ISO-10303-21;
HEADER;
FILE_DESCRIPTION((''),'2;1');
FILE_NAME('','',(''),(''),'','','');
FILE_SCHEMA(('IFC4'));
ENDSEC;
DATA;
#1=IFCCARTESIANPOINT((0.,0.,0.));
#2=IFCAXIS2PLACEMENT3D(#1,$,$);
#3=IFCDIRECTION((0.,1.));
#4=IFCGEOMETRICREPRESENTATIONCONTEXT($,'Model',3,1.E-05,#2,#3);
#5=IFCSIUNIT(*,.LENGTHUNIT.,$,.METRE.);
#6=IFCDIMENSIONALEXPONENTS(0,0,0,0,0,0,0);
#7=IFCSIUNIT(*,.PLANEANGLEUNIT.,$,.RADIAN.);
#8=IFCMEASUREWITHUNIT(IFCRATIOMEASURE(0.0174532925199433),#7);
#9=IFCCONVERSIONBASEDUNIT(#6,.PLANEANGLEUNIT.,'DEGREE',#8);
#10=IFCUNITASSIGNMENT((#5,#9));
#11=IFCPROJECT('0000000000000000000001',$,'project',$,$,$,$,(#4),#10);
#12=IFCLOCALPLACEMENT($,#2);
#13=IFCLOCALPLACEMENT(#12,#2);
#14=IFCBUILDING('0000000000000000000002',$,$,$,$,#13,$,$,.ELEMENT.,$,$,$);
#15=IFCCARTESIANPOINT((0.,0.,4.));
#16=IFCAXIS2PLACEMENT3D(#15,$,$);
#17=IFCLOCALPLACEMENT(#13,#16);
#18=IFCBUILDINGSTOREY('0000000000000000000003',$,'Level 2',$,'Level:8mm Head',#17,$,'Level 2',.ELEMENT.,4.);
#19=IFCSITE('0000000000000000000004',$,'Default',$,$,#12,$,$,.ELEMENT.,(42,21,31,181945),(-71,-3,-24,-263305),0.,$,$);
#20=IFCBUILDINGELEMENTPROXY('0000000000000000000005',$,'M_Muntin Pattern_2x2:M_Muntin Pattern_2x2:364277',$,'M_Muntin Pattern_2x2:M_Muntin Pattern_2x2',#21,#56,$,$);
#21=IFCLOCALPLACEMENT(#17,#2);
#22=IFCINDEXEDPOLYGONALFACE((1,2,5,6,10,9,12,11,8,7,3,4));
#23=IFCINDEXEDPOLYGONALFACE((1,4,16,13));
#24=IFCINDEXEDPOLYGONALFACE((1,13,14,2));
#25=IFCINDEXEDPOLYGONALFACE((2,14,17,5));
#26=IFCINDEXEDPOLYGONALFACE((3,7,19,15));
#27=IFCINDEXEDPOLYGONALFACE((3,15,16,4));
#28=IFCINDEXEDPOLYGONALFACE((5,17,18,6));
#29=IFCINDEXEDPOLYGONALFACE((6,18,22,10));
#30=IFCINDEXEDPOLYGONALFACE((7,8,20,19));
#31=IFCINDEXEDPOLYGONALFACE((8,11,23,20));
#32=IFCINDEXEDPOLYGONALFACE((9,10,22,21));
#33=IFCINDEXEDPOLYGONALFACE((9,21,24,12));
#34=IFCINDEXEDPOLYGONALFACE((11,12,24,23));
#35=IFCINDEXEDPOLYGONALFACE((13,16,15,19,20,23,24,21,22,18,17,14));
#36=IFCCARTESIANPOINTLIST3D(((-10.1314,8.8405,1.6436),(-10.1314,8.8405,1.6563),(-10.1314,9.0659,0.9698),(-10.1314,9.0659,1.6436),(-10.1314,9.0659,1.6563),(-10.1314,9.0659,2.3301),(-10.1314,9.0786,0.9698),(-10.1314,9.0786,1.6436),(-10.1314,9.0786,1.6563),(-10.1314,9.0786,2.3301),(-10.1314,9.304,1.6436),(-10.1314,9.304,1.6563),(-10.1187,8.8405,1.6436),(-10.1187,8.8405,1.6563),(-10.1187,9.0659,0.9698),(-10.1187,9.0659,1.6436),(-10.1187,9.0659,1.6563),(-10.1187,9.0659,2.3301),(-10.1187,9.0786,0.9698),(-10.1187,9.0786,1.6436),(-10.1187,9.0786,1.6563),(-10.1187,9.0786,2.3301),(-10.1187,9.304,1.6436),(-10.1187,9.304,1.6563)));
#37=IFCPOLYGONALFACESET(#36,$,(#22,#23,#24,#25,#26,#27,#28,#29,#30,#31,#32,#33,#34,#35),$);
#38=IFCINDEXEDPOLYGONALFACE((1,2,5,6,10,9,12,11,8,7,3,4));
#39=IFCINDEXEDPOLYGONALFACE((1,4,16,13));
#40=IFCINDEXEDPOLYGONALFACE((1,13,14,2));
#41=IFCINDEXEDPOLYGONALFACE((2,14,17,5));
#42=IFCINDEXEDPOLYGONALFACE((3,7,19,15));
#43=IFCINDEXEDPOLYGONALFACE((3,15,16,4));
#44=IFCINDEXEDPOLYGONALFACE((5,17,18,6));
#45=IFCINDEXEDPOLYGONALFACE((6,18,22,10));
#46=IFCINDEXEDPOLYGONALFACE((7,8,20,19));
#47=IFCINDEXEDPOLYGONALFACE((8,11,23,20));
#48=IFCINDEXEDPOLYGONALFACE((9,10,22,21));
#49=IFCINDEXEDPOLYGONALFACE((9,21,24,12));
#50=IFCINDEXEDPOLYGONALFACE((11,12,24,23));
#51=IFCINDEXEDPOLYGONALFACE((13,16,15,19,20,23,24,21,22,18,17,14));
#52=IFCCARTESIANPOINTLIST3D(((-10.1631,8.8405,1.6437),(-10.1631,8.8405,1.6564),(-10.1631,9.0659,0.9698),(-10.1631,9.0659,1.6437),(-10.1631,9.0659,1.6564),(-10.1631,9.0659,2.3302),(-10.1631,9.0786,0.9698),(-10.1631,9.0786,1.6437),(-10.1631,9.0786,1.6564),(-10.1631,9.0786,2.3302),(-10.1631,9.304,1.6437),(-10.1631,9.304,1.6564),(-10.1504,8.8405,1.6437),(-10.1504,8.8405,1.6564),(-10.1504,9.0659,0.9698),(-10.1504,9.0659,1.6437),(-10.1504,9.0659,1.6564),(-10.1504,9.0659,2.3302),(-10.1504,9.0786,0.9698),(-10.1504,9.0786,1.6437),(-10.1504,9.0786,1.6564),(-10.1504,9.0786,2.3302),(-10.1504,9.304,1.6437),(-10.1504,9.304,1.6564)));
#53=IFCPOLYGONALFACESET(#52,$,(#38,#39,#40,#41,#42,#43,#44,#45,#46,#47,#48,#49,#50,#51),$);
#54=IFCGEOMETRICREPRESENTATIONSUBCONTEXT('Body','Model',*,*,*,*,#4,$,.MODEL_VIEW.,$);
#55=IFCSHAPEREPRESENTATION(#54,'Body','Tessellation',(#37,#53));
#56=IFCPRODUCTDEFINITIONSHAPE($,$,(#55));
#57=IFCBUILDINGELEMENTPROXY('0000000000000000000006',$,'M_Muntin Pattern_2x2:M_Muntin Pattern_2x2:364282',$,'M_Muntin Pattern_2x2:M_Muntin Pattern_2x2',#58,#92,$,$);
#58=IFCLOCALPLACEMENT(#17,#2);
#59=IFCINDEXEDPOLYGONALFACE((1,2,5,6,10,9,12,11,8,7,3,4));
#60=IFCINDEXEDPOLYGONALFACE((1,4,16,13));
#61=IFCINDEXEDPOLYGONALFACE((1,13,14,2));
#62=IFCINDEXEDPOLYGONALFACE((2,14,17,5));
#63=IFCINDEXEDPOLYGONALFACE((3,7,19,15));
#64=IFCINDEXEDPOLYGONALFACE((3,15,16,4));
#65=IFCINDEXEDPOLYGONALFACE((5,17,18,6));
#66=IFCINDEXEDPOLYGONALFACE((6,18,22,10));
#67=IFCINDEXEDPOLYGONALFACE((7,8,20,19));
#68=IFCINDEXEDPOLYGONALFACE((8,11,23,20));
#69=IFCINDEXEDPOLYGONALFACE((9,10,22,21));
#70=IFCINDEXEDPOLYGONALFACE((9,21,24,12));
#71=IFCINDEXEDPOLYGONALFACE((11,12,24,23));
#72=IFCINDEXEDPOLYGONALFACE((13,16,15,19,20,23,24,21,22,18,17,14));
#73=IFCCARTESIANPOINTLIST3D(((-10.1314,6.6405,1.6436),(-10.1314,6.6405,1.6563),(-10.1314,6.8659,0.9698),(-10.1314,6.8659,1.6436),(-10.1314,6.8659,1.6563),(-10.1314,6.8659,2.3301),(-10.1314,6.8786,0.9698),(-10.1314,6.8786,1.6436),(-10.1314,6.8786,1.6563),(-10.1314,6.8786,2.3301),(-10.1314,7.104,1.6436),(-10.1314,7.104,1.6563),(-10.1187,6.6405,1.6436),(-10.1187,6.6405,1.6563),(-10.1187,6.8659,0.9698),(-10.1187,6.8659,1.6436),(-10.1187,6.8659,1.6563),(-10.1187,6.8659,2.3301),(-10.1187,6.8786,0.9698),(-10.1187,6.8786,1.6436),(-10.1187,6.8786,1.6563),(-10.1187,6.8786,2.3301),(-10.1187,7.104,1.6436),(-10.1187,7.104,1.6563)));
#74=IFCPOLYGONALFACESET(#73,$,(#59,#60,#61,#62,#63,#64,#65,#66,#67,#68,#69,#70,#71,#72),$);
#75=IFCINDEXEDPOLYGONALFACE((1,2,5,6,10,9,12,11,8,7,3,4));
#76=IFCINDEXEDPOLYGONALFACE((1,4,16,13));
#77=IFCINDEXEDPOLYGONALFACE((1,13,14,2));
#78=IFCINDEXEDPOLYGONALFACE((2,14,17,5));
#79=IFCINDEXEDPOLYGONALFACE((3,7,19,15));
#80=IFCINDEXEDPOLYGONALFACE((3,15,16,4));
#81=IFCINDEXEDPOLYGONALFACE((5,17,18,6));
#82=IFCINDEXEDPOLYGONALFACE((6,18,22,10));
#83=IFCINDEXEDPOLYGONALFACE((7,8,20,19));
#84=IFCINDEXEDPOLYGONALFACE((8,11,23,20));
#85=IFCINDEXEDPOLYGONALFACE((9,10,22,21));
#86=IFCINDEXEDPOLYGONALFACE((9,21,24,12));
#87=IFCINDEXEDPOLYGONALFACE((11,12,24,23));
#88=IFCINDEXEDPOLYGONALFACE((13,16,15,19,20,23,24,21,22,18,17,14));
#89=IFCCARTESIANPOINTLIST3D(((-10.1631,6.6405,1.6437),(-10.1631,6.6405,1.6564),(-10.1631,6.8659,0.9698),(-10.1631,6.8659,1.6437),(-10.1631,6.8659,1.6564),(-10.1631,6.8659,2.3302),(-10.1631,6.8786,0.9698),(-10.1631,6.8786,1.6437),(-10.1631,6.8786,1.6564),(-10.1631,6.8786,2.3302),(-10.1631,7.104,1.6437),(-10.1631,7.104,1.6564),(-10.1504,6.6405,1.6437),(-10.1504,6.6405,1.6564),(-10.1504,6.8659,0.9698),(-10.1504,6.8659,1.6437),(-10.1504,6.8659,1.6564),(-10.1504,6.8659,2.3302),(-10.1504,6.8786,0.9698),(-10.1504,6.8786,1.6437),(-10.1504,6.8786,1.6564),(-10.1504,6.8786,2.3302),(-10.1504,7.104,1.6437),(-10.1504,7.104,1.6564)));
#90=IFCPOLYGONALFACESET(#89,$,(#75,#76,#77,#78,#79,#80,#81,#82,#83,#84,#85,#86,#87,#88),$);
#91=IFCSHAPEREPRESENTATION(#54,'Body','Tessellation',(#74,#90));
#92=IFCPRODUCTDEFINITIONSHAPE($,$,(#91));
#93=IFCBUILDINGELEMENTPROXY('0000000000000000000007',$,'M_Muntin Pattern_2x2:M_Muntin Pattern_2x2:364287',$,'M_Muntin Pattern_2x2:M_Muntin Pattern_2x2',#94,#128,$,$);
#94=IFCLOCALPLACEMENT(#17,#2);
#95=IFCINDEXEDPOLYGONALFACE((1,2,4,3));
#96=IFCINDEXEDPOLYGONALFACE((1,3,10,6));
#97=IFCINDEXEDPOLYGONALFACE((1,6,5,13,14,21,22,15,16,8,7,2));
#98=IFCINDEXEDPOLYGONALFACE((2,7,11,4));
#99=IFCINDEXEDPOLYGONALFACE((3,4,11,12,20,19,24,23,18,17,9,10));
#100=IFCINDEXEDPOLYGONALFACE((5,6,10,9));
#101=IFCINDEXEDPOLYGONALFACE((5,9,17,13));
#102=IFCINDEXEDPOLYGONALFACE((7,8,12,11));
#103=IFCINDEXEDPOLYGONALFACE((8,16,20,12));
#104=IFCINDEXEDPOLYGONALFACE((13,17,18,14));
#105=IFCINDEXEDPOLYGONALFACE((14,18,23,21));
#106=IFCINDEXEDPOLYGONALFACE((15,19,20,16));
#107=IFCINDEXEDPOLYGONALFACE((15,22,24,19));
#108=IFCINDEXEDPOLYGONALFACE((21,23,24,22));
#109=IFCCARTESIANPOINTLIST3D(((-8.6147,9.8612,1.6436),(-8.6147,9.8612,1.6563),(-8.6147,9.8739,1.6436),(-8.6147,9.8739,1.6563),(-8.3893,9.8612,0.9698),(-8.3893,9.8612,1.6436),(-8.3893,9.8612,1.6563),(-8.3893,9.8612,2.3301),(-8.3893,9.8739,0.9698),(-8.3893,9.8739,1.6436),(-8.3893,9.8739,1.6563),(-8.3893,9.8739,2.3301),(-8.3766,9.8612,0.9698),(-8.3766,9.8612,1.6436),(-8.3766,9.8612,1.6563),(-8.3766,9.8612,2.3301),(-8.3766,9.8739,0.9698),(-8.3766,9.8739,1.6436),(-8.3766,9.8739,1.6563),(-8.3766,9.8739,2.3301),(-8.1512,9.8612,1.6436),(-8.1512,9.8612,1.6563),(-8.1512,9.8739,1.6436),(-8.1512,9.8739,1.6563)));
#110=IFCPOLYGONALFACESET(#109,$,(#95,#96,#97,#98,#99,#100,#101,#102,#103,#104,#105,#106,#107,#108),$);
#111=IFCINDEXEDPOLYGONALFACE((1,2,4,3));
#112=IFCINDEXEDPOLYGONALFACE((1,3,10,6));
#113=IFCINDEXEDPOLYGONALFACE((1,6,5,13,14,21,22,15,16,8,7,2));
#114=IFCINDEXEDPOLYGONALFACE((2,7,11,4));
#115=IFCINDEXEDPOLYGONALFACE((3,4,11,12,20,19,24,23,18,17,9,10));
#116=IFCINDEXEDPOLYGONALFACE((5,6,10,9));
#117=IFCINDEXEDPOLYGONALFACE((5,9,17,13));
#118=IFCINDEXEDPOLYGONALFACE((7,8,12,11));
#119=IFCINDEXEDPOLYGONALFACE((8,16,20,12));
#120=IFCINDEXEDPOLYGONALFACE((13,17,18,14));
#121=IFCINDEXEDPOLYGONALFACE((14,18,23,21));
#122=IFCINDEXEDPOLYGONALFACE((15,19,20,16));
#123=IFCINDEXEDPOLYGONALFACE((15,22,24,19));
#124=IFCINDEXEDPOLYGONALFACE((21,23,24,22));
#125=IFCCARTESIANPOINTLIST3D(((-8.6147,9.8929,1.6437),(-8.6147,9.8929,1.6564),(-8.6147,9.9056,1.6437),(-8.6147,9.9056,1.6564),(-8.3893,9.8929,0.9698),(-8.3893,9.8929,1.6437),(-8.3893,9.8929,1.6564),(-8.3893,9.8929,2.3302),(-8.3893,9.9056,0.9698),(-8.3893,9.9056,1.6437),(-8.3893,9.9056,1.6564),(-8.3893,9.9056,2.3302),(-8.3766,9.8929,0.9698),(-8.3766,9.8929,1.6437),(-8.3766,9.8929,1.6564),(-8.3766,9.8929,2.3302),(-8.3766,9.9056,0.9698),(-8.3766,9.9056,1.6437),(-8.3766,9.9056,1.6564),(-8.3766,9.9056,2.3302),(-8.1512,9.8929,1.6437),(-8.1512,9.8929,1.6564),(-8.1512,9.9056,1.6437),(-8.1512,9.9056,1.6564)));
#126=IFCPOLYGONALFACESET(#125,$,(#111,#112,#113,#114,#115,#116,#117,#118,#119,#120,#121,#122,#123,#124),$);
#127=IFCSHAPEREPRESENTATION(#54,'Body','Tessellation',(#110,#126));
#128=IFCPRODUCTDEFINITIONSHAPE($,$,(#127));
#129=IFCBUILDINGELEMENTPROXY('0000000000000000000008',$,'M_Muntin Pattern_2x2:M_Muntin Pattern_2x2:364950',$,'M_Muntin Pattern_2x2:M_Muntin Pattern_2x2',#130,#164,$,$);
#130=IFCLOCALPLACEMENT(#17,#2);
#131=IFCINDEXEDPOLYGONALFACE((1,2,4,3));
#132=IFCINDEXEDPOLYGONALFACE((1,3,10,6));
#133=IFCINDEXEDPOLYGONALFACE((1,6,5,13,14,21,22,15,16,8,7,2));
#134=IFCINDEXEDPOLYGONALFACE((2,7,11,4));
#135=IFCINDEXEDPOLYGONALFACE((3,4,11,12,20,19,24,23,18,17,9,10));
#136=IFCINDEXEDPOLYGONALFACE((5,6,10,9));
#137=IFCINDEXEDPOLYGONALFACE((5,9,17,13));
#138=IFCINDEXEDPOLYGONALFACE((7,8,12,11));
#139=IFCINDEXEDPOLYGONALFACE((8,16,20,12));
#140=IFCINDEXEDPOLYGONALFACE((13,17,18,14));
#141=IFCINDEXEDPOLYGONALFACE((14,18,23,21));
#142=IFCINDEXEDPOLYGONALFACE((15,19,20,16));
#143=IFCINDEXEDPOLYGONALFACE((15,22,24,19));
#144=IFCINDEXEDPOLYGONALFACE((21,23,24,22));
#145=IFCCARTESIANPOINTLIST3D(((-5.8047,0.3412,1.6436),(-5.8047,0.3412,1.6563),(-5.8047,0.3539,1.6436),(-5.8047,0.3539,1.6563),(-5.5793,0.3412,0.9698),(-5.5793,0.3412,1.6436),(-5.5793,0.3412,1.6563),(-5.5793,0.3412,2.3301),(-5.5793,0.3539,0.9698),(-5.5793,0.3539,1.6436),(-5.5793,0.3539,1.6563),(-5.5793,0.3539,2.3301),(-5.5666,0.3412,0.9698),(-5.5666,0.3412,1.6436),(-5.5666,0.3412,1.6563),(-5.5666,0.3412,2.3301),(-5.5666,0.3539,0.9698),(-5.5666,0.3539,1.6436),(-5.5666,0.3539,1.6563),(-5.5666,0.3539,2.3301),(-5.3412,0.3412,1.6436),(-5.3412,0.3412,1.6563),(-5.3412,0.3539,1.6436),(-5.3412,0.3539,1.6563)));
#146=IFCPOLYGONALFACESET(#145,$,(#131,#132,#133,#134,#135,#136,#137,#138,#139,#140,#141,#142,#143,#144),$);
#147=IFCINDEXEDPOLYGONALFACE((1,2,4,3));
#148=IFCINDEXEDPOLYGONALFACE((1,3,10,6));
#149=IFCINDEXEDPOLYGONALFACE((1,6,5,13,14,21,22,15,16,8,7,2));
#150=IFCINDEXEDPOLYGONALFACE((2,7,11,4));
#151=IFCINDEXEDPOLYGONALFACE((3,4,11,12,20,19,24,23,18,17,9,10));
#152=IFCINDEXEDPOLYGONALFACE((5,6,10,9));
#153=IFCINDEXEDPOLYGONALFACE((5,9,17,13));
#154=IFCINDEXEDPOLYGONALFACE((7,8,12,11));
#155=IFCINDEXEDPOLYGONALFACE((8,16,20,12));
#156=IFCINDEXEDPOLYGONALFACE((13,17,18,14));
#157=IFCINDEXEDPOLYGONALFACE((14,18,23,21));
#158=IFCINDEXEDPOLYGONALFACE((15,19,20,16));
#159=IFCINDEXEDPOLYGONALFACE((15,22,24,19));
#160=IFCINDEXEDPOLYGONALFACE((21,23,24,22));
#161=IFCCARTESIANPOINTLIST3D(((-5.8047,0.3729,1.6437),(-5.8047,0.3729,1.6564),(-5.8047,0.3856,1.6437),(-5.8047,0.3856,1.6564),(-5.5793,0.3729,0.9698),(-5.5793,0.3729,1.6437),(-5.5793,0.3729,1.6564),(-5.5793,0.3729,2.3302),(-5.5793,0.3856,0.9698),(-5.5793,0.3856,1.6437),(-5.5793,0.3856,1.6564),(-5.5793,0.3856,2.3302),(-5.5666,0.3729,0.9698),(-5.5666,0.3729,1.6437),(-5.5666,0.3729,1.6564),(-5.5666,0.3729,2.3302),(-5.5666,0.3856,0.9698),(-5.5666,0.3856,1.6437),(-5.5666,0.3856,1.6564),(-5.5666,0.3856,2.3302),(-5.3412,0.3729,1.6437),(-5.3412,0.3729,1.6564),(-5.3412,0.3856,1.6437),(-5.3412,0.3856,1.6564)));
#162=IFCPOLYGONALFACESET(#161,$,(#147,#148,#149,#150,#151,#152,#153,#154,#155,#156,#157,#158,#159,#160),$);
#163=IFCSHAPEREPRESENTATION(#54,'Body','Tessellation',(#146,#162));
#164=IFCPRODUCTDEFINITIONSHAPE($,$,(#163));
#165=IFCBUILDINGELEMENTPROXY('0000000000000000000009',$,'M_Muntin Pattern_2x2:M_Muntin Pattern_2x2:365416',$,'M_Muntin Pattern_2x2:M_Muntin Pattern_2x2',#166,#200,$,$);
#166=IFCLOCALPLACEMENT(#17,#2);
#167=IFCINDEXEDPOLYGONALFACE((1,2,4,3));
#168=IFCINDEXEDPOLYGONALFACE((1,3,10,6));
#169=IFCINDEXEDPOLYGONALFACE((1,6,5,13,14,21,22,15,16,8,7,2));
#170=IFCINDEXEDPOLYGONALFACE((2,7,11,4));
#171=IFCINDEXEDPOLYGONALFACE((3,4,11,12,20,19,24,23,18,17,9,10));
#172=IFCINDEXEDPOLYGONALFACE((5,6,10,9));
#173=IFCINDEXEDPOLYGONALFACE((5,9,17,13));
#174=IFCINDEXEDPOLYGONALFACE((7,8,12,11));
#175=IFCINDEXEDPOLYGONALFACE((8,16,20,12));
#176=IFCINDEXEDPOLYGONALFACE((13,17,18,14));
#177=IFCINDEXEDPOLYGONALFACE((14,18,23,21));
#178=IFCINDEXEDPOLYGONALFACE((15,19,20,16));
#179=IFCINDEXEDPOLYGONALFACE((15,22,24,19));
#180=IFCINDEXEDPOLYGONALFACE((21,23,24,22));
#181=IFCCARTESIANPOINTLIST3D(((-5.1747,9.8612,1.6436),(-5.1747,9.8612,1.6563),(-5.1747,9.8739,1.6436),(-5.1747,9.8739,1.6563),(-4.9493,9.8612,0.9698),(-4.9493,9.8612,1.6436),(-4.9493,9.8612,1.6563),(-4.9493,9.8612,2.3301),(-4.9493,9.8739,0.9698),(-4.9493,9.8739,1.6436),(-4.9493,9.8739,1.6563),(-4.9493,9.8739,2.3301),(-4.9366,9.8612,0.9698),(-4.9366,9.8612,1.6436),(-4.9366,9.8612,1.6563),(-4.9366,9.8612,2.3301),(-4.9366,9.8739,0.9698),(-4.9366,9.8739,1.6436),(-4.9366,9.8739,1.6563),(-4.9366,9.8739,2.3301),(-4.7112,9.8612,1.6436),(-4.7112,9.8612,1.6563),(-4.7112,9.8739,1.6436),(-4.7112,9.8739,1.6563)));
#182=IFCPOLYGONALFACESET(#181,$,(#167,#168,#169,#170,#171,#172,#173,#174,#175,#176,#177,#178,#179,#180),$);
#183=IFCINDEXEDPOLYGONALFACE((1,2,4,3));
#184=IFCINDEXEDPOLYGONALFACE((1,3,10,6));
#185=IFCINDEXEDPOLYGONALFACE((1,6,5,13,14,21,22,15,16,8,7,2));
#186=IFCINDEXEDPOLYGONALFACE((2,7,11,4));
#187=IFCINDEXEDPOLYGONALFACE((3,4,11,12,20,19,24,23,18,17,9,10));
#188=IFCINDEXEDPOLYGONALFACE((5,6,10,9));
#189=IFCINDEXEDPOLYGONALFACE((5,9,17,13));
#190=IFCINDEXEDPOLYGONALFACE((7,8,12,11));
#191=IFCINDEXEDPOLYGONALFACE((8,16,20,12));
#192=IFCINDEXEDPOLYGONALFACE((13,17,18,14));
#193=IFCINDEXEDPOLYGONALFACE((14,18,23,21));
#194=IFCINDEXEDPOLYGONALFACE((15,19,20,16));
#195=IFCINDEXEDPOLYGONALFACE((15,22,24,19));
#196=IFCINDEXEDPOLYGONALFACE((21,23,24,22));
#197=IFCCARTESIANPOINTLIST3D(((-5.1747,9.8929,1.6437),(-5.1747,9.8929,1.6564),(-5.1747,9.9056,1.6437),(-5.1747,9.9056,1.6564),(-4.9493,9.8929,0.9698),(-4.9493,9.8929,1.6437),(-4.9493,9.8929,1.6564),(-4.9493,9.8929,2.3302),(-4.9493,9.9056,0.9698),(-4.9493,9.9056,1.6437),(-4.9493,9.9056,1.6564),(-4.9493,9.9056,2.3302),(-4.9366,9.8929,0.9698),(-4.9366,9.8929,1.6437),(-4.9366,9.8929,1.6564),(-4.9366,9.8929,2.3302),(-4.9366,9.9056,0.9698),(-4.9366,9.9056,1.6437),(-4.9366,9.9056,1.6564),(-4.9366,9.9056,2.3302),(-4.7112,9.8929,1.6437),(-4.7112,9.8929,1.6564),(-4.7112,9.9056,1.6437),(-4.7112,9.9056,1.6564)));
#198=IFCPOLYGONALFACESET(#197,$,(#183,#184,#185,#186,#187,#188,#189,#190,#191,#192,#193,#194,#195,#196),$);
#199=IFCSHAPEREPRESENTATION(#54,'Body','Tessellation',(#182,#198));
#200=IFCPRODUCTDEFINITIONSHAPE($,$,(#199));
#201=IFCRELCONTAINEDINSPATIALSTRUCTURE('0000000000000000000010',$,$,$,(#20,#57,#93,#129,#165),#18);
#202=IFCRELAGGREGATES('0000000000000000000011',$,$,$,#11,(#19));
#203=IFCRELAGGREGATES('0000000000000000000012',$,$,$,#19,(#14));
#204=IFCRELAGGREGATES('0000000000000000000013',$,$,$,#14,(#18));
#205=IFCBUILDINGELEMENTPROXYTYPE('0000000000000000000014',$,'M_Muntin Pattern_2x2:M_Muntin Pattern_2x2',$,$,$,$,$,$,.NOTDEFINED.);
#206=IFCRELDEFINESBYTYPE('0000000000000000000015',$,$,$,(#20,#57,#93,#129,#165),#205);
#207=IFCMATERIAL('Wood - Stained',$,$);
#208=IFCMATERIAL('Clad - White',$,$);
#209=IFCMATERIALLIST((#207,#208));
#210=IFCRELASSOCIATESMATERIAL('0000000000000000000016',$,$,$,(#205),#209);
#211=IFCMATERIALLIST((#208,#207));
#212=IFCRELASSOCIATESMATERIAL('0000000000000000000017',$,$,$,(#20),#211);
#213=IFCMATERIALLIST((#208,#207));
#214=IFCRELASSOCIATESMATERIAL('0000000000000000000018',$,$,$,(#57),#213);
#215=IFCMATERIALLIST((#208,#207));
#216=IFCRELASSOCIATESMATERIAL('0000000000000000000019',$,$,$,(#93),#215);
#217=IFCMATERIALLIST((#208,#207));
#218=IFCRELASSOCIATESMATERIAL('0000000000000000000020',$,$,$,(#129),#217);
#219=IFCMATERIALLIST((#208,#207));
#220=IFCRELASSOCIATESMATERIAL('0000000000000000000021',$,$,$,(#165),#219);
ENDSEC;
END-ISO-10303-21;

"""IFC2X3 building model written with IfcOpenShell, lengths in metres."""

from ifc_helpers import new_model, entity, si_unit, converted_unit, direction, frame, origin, place, context, subcontext, project, spatial, polyline, outline, extrude, source, transform, mapped, material, material_list, type_object, type_shapes, element, save


model = new_model("IFC2X3")

# Units and contexts
model_context = context("Model", 3, precision=1e-05, world=origin(), true_north=direction((0.0, 1.0)))
body_context = subcontext(model_context, "Body", "Model", "MODEL_VIEW")
ifc_project = project(units=[si_unit("LENGTHUNIT", "METRE"), converted_unit("PLANEANGLEUNIT", "DEGREE", entity("IfcRatioMeasure", 0.0174532925199433), si_unit("PLANEANGLEUNIT", "RADIAN"), dimensions=[0, 0, 0, 0, 0, 0, 0])], contexts=[model_context])

# Site, building, storey
site_placement = place(None, origin())
site = spatial("IfcSite", under=ifc_project, at=site_placement, Name="Default", CompositionType="ELEMENT", RefLatitude=(42, 21, 31, 181945), RefLongitude=(-71, -3, -24, -263305), RefElevation=0.0)
building_placement = place(site_placement, origin())
building = spatial("IfcBuilding", under=site, at=building_placement, CompositionType="ELEMENT")
storey_placement = place(building_placement, frame((0.0, 0.0, 4.0)))
storey = spatial("IfcBuildingStorey", under=building, at=storey_placement, Name="Level 2", ObjectType="Level:8mm Head", LongName="Level 2", CompositionType="ELEMENT", Elevation=4.0)

# Building element proxies
ifc_material_1 = material(Name="Clad - White")
ifc_material_2 = material(Name="Wood - Stained")
ifc_material_list_1 = material_list([ifc_material_1, ifc_material_2])
ifc_material_list_2 = material_list([ifc_material_2, ifc_material_1])
building_element_proxy_type_1 = type_object("IfcBuildingElementProxyType", Name="M_Muntin Pattern_2x2:M_Muntin Pattern_2x2", PredefinedType="NOTDEFINED", material=ifc_material_list_2)
shared_shape_1 = source(origin(), body_context, "Body", "SweptSolid", [
    extrude(outline(polyline([(0.0064, -0.0064), (0.6801, -0.0064), (0.6801, 0.0063), (0.0064, 0.0063), (0.0064, 0.2317), (-0.0063, 0.2317), (-0.0063, 0.0063), (-0.6802, 0.0063), (-0.6802, -0.0064), (-0.0063, -0.0064), (-0.0063, -0.2317), (0.0064, -0.2317), (0.0064, -0.0064)])), frame((0.0, 0.0095, 0.6801), z_axis=(0.0, 1.0, 0.0), x_axis=(0.0, 0.0, 1.0)), (0.0, 0.0, 1.0), 0.0127),
    extrude(outline(polyline([(0.0064, -0.0064), (0.6802, -0.0064), (0.6802, 0.0063), (0.0064, 0.0063), (0.0064, 0.2317), (-0.0063, 0.2317), (-0.0063, 0.0063), (-0.6802, 0.0063), (-0.6802, -0.0064), (-0.0063, -0.0064), (-0.0063, -0.2317), (0.0064, -0.2317), (0.0064, -0.0064)])), frame((0.0, -0.0222, 0.6802), z_axis=(0.0, 1.0, 0.0), x_axis=(0.0, 0.0, 1.0)), (0.0, 0.0, 1.0), 0.0127),
])
type_shapes(building_element_proxy_type_1, [shared_shape_1])
proxy_1_placement = place(storey_placement, frame((-10.1409, 9.0723, 0.9698), z_axis=(0.0, 0.0, 1.0), x_axis=(0.0, -1.0, 0.0)))
element("IfcBuildingElementProxy", 1, at=proxy_1_placement, inside=storey, type_object=building_element_proxy_type_1, material=ifc_material_list_1, Name="M_Muntin Pattern_2x2:M_Muntin Pattern_2x2:364277", ObjectType="M_Muntin Pattern_2x2:M_Muntin Pattern_2x2", context=body_context, shape_type="MappedRepresentation", body=[
    mapped(shared_shape_1, transform((0.0, 0.0, 0.0), scale=1.0)),
])
ifc_material_list_3 = material_list([ifc_material_1, ifc_material_2])
proxy_2_placement = place(storey_placement, frame((-10.1409, 6.8723, 0.9698), z_axis=(0.0, 0.0, 1.0), x_axis=(0.0, -1.0, 0.0)))
element("IfcBuildingElementProxy", 2, at=proxy_2_placement, inside=storey, type_object=building_element_proxy_type_1, material=ifc_material_list_3, Name="M_Muntin Pattern_2x2:M_Muntin Pattern_2x2:364282", ObjectType="M_Muntin Pattern_2x2:M_Muntin Pattern_2x2", context=body_context, shape_type="MappedRepresentation", body=[
    mapped(shared_shape_1, transform((0.0, 0.0, 0.0), scale=1.0)),
])
ifc_material_list_4 = material_list([ifc_material_1, ifc_material_2])
proxy_3_placement = place(storey_placement, frame((-8.383, 9.8834, 0.9698), z_axis=(0.0, 0.0, 1.0), x_axis=(-1.0, 0.0, 0.0)))
element("IfcBuildingElementProxy", 3, at=proxy_3_placement, inside=storey, type_object=building_element_proxy_type_1, material=ifc_material_list_4, Name="M_Muntin Pattern_2x2:M_Muntin Pattern_2x2:364287", ObjectType="M_Muntin Pattern_2x2:M_Muntin Pattern_2x2", context=body_context, shape_type="MappedRepresentation", body=[
    mapped(shared_shape_1, transform((0.0, 0.0, 0.0), scale=1.0)),
])
ifc_material_list_5 = material_list([ifc_material_1, ifc_material_2])
proxy_4_placement = place(storey_placement, frame((-5.573, 0.3634, 0.9698), z_axis=(0.0, 0.0, 1.0), x_axis=(-1.0, 0.0, 0.0)))
element("IfcBuildingElementProxy", 4, at=proxy_4_placement, inside=storey, type_object=building_element_proxy_type_1, material=ifc_material_list_5, Name="M_Muntin Pattern_2x2:M_Muntin Pattern_2x2:364950", ObjectType="M_Muntin Pattern_2x2:M_Muntin Pattern_2x2", context=body_context, shape_type="MappedRepresentation", body=[
    mapped(shared_shape_1, transform((0.0, 0.0, 0.0), scale=1.0)),
])
ifc_material_list_6 = material_list([ifc_material_1, ifc_material_2])
proxy_5_placement = place(storey_placement, frame((-4.943, 9.8834, 0.9698), z_axis=(0.0, 0.0, 1.0), x_axis=(-1.0, 0.0, 0.0)))
element("IfcBuildingElementProxy", 5, at=proxy_5_placement, inside=storey, type_object=building_element_proxy_type_1, material=ifc_material_list_6, Name="M_Muntin Pattern_2x2:M_Muntin Pattern_2x2:365416", ObjectType="M_Muntin Pattern_2x2:M_Muntin Pattern_2x2", context=body_context, shape_type="MappedRepresentation", body=[
    mapped(shared_shape_1, transform((0.0, 0.0, 0.0), scale=1.0)),
])

save(model, "model.ifc")
